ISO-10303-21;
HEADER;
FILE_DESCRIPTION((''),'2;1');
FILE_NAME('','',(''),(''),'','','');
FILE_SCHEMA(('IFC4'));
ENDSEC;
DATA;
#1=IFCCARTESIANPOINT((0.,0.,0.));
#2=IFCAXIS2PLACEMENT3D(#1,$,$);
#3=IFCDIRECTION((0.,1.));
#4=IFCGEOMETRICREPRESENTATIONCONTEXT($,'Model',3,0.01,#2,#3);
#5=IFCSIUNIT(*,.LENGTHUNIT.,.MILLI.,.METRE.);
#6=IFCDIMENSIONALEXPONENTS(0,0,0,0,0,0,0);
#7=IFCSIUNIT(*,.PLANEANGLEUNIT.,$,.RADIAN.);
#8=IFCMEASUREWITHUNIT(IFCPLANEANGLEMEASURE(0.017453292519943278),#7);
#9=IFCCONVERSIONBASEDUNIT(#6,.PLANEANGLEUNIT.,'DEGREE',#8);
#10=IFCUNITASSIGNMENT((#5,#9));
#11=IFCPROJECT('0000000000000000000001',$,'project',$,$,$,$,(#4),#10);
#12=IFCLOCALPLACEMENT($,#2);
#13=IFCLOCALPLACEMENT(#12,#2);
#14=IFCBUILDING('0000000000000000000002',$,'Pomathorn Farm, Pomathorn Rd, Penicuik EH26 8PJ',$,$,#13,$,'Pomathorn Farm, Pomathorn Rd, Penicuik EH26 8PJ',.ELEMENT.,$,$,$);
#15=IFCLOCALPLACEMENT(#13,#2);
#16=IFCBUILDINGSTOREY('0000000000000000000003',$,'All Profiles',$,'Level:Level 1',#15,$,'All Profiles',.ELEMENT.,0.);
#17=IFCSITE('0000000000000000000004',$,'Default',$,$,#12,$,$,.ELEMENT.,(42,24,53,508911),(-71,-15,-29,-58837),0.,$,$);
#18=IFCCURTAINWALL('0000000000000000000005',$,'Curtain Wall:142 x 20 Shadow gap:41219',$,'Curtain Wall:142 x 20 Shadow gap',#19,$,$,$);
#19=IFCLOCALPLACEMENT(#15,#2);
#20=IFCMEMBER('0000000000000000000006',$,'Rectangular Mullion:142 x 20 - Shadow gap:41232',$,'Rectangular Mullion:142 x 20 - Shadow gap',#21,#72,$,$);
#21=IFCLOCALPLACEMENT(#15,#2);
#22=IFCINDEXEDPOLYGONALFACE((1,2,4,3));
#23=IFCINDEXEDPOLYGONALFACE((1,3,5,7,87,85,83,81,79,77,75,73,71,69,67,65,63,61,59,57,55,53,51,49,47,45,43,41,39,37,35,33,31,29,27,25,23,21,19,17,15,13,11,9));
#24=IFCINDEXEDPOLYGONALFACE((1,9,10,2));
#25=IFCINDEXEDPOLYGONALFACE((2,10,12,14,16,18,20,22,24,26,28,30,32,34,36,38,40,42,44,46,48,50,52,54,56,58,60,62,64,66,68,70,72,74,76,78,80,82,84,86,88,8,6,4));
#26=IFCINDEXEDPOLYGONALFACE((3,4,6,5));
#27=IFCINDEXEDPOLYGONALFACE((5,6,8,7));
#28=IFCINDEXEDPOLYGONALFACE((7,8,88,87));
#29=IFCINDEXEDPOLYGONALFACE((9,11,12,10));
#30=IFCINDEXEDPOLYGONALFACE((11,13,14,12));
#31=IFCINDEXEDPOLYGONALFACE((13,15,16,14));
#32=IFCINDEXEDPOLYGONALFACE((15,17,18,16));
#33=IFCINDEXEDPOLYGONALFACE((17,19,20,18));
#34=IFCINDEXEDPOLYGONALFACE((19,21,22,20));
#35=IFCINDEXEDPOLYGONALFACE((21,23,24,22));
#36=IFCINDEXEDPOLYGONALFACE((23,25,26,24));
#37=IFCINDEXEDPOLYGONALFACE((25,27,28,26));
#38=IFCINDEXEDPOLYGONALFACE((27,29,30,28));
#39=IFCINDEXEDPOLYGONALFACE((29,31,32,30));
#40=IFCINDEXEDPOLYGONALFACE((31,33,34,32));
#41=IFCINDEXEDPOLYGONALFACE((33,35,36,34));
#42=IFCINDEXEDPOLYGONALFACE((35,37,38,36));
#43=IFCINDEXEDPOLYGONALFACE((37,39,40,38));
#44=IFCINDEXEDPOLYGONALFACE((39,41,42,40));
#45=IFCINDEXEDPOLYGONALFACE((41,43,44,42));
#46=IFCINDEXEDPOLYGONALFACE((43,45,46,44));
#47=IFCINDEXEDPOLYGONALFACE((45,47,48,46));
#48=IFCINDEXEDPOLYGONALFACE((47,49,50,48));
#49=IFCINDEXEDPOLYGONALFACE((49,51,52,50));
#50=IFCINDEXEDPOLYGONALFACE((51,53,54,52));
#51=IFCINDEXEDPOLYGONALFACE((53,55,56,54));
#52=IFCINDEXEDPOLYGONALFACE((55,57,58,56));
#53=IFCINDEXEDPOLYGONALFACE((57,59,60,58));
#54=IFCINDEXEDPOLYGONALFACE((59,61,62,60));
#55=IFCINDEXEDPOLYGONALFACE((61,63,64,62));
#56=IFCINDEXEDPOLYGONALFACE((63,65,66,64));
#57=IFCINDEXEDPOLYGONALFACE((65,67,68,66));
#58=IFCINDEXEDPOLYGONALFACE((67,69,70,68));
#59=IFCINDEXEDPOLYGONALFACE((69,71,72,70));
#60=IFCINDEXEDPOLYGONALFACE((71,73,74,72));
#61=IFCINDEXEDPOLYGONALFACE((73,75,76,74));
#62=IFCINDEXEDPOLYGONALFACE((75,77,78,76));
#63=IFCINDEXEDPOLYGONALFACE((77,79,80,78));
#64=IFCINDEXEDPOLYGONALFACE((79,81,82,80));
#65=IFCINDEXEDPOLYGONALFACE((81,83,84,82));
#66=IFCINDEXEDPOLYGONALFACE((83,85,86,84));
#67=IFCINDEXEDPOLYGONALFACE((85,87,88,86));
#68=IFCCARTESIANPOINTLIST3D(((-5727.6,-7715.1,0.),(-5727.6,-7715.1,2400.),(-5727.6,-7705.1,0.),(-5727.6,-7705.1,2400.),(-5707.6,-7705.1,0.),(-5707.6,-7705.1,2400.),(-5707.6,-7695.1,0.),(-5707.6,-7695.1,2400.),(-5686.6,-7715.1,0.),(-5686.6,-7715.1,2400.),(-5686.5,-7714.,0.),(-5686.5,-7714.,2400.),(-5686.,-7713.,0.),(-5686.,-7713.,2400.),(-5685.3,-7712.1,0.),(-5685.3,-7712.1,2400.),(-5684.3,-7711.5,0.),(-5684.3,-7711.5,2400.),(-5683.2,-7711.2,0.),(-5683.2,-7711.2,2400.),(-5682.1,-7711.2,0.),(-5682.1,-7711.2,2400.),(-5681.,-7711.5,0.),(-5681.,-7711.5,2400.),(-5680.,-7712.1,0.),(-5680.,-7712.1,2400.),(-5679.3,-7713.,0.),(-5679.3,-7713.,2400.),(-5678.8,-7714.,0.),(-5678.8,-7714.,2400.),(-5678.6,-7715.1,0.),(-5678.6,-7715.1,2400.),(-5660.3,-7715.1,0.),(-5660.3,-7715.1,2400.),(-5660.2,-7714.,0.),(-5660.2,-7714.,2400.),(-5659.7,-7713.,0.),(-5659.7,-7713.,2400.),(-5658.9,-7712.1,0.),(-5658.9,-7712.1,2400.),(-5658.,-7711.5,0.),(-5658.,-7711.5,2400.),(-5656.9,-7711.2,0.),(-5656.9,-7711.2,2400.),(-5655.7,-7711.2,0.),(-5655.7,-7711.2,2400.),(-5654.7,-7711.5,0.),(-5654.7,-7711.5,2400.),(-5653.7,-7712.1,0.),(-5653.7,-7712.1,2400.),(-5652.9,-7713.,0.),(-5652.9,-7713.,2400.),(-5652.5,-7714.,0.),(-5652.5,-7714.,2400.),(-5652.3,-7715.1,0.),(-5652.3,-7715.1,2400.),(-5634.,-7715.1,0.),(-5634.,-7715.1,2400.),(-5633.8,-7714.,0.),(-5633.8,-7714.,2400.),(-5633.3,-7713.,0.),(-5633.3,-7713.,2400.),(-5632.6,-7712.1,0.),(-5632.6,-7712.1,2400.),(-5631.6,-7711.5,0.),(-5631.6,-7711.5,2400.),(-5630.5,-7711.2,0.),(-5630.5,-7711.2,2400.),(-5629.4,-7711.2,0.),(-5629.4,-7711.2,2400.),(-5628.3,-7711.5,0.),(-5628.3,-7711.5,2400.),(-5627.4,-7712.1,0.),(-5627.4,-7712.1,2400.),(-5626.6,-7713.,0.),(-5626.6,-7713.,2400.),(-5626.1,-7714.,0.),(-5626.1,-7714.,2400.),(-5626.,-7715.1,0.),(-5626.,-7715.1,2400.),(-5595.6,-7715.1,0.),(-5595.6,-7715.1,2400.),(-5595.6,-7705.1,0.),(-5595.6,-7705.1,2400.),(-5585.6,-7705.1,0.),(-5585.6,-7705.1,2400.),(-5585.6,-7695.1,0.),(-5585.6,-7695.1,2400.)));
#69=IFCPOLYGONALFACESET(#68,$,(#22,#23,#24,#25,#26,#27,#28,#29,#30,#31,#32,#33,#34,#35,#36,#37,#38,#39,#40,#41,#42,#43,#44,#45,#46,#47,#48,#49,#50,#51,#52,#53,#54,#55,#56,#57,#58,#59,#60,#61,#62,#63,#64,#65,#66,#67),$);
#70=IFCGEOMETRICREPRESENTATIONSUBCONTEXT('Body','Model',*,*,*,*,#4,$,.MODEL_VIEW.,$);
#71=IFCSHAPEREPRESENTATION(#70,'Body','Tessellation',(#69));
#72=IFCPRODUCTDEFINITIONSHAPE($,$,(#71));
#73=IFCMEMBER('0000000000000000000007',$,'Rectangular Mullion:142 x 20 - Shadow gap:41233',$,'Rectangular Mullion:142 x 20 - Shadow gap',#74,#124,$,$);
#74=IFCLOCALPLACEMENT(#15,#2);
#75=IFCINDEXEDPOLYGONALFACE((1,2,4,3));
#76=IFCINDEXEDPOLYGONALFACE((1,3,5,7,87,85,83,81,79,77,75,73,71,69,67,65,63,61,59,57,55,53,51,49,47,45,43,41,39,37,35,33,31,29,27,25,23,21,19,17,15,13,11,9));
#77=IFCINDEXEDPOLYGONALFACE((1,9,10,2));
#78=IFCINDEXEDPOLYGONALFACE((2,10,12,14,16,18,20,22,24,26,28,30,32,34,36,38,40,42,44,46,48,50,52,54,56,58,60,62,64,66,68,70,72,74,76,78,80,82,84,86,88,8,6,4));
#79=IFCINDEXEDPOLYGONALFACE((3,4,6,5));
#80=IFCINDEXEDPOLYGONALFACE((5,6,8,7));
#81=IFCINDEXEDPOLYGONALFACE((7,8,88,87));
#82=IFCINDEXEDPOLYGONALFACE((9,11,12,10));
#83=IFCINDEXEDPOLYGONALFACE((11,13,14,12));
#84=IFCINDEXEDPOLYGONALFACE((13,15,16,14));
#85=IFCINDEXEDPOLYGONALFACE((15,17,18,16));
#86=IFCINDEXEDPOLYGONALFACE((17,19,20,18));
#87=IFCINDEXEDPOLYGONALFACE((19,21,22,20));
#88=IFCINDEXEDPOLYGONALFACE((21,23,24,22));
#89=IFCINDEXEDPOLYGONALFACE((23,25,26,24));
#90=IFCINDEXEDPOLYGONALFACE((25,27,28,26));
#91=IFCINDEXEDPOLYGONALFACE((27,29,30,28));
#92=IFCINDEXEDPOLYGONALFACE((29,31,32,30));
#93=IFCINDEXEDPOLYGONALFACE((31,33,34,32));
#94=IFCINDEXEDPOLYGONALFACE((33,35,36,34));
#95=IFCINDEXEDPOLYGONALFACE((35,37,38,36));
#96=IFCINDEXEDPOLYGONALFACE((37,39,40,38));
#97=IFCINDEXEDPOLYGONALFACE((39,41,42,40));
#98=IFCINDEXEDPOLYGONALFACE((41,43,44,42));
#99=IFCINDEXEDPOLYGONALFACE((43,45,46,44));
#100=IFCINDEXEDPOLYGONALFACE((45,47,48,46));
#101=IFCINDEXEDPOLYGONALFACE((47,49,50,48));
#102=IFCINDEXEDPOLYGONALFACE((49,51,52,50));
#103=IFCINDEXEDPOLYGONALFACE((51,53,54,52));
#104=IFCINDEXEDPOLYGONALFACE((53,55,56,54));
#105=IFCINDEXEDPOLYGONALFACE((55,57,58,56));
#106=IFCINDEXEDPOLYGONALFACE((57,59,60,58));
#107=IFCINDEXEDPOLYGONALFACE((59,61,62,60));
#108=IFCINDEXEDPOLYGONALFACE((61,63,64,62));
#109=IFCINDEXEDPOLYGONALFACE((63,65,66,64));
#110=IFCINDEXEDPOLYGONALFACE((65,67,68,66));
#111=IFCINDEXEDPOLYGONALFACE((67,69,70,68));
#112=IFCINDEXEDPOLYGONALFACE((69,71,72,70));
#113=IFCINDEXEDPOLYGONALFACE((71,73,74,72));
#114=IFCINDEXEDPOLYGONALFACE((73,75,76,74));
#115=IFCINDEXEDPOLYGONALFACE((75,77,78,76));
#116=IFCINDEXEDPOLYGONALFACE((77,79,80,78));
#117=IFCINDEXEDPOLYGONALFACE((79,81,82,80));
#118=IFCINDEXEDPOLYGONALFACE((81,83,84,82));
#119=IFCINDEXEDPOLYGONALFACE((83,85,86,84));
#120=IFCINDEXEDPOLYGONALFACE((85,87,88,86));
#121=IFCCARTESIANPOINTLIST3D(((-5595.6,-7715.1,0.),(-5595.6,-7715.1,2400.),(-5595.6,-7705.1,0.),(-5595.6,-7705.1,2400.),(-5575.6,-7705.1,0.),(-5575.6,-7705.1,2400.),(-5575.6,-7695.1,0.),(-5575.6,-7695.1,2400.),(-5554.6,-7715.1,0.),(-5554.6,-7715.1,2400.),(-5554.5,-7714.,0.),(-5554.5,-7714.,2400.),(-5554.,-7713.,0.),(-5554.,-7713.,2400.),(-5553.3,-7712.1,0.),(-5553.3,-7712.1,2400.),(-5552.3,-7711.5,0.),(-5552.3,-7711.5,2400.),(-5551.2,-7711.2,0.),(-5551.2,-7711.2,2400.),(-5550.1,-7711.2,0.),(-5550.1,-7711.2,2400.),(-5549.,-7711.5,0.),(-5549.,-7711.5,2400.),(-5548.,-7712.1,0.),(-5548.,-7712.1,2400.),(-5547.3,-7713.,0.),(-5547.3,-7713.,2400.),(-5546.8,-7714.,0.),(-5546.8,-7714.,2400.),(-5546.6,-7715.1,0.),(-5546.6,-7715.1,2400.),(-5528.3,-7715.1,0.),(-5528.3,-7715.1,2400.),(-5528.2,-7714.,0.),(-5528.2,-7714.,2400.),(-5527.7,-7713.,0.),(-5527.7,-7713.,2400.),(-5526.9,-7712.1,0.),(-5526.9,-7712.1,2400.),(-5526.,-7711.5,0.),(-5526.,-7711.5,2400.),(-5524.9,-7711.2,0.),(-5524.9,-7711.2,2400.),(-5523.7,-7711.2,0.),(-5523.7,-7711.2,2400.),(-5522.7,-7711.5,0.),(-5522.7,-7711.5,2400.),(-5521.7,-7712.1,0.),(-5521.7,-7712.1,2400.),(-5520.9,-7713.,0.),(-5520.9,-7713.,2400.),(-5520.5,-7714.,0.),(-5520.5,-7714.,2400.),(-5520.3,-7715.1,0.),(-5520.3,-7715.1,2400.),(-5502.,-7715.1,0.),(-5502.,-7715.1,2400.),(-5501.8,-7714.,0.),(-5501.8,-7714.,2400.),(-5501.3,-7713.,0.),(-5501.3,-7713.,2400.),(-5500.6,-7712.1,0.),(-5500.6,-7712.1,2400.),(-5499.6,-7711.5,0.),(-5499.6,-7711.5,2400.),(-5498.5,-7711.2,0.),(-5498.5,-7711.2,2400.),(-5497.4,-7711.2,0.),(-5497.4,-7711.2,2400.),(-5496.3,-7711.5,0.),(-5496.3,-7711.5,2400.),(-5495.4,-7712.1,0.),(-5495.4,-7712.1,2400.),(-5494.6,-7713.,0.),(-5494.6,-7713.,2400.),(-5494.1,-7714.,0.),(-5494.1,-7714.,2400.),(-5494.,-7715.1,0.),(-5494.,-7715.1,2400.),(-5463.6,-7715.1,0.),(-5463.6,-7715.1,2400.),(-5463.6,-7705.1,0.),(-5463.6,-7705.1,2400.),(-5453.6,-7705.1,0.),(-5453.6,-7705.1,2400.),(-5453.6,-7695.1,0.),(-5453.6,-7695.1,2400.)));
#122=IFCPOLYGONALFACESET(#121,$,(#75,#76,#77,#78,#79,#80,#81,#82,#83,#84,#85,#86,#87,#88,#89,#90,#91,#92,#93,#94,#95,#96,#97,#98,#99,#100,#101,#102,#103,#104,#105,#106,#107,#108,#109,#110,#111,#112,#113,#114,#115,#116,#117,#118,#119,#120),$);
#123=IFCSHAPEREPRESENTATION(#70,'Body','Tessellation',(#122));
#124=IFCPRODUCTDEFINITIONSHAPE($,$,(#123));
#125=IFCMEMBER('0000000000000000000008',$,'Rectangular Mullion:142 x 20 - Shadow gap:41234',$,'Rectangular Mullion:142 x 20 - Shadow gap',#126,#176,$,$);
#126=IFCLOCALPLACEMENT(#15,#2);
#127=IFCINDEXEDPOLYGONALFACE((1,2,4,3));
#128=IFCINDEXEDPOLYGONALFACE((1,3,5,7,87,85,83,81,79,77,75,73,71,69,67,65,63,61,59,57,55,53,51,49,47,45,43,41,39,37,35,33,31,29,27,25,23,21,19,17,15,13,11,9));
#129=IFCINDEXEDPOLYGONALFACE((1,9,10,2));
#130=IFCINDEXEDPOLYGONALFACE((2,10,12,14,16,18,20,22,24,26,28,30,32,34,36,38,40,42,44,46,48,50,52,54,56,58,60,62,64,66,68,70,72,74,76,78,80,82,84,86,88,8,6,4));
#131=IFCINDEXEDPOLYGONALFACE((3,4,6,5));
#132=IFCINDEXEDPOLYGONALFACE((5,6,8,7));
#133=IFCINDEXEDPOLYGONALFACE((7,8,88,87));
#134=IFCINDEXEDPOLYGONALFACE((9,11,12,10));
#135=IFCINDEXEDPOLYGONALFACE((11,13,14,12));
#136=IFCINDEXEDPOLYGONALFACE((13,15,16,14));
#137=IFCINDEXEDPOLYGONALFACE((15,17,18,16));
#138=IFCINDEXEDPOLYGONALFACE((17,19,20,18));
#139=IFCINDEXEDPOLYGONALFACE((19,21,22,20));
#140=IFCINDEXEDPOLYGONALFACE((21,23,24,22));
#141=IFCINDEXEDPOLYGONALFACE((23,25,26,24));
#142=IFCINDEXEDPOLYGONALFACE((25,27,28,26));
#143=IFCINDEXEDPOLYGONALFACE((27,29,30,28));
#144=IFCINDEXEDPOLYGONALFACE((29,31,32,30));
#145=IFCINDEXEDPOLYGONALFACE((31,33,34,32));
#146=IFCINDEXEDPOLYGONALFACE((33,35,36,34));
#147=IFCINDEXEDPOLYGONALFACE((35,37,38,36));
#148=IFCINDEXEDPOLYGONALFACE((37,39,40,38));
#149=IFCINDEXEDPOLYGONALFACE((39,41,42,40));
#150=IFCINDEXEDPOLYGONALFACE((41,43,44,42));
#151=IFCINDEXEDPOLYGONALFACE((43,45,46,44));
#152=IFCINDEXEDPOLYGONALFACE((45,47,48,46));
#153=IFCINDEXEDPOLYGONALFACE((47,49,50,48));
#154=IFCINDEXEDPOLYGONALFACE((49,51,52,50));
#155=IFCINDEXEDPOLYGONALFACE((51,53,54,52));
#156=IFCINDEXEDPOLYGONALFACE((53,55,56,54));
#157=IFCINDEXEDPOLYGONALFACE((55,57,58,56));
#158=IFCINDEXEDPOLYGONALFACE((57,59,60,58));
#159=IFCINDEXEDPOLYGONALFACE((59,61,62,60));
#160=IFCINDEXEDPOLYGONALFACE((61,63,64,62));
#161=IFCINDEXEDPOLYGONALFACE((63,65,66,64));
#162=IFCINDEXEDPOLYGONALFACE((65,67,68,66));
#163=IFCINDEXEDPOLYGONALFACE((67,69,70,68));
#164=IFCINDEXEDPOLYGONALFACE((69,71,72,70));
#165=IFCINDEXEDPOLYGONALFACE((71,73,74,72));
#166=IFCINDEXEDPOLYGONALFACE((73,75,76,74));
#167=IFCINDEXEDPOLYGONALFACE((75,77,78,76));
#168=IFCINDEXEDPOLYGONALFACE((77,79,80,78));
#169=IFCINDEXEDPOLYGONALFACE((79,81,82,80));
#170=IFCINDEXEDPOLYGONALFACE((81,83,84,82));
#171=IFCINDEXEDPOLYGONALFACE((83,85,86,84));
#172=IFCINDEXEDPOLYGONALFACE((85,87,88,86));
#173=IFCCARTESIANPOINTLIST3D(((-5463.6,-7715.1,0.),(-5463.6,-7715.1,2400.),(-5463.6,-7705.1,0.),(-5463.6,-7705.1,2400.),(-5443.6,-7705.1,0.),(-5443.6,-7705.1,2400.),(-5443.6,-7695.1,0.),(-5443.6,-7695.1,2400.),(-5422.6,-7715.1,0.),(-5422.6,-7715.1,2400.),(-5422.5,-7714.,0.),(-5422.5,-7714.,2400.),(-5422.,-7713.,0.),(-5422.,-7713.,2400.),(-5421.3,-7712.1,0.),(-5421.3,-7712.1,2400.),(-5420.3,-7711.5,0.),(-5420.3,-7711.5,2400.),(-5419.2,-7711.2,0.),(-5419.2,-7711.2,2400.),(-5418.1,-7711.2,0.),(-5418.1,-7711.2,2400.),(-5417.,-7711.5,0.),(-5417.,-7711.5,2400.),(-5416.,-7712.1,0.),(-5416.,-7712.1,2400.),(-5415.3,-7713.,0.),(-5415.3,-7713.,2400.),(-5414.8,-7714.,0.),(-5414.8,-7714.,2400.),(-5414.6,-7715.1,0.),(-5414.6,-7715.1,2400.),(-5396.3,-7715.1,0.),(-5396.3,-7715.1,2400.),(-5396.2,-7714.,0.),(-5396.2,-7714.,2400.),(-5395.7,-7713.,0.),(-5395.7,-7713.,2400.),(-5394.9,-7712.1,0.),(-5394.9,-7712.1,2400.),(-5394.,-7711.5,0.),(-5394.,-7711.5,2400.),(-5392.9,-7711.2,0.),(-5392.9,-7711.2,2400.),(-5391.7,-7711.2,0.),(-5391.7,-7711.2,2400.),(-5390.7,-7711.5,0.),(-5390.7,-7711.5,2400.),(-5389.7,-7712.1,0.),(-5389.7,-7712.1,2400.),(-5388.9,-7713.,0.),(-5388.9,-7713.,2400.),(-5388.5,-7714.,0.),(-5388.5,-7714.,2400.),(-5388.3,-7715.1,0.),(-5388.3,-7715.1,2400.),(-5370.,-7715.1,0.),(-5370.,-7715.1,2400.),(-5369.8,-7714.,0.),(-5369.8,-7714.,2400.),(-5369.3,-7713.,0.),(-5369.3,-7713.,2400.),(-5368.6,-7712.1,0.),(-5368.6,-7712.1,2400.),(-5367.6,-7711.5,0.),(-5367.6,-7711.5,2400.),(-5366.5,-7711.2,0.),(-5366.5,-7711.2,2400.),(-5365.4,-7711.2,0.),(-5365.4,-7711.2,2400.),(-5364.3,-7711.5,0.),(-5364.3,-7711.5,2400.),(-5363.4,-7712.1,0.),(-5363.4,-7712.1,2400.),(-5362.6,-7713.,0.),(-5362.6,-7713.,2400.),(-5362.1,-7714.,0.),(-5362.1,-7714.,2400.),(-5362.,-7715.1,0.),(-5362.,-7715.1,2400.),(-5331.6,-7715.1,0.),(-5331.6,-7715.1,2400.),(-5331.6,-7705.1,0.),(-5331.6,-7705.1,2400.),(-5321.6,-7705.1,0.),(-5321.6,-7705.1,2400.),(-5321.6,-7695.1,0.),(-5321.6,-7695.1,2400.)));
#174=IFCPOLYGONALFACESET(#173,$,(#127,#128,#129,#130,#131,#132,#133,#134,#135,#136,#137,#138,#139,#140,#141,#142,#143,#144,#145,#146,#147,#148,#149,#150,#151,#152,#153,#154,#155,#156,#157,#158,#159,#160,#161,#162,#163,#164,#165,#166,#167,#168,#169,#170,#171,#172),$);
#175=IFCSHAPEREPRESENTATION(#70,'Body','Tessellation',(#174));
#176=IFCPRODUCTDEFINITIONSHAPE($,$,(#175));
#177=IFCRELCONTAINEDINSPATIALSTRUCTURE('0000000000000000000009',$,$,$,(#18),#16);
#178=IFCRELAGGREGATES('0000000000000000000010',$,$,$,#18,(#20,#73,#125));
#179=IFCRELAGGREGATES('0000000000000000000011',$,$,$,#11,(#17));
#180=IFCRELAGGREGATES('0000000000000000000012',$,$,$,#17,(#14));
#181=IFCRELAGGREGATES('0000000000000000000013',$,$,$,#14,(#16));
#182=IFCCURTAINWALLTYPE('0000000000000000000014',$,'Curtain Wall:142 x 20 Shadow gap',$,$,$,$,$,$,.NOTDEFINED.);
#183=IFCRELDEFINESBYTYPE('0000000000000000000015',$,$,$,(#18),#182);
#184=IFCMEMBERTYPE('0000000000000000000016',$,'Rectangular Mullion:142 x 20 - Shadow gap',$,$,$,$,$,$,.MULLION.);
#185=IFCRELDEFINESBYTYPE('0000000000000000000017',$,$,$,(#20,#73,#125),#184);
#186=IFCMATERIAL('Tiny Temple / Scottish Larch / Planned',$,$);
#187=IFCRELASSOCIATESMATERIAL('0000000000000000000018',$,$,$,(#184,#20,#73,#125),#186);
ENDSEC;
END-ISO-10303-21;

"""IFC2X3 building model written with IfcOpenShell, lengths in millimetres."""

from ifc_helpers import new_model, entity, si_unit, converted_unit, direction, frame, frame_2d, origin, place, context, subcontext, project, spatial, polyline, circle_curve, parameter, trimmed, segment, composite_curve, outline, extrude, source, transform, mapped, material, type_object, type_shapes, element, aggregate, save


model = new_model("IFC2X3")

# Units and contexts
model_context = context("Model", 3, precision=0.01, world=origin(), true_north=direction((0.0, 1.0)))
body_context = subcontext(model_context, "Body", "Model", "MODEL_VIEW")
ifc_project = project(units=[si_unit("LENGTHUNIT", "METRE", prefix="MILLI"), converted_unit("PLANEANGLEUNIT", "DEGREE", entity("IfcPlaneAngleMeasure", 0.017453292519943278), si_unit("PLANEANGLEUNIT", "RADIAN"), dimensions=[0, 0, 0, 0, 0, 0, 0])], contexts=[model_context])

# Site, building, storey
site_placement = place(None, origin())
site = spatial("IfcSite", under=ifc_project, at=site_placement, Name="Default", CompositionType="ELEMENT", RefLatitude=(42, 24, 53, 508911), RefLongitude=(-71, -15, -29, -58837), RefElevation=0.0)
building_placement = place(site_placement, origin())
building = spatial("IfcBuilding", under=site, at=building_placement, Name="Pomathorn Farm, Pomathorn Rd, Penicuik EH26 8PJ", LongName="Pomathorn Farm, Pomathorn Rd, Penicuik EH26 8PJ", CompositionType="ELEMENT")
storey_placement = place(building_placement, origin())
storey = spatial("IfcBuildingStorey", under=building, at=storey_placement, Name="All Profiles", ObjectType="Level:Level 1", LongName="All Profiles", CompositionType="ELEMENT", Elevation=0.0)

# Curtain wall, members
curtain_wall_type_1 = type_object("IfcCurtainWallType", Name="Curtain Wall:142 x 20 Shadow gap", PredefinedType="NOTDEFINED")
curtain_wall_1_placement = place(storey_placement, origin())
curtain_wall_1 = element("IfcCurtainWall", 1, at=curtain_wall_1_placement, inside=storey, type_object=curtain_wall_type_1, Name="Curtain Wall:142 x 20 Shadow gap:41219", ObjectType="Curtain Wall:142 x 20 Shadow gap")
ifc_material = material(Name="Tiny Temple / Scottish Larch / Planned")
member_type_1 = type_object("IfcMemberType", Name="Rectangular Mullion:142 x 20 - Shadow gap", PredefinedType="MULLION", material=ifc_material)
shared_shape_1 = source(origin(), body_context, "Body", "SweptSolid", [
    extrude(outline(composite_curve([segment(polyline([(29.1, -5.7), (59.4, -5.7)]), True, "CONTINUOUS"), segment(polyline([(59.4, -5.7), (59.4, 4.3)]), True, "CONTINUOUS"), segment(polyline([(59.4, 4.3), (69.4, 4.3)]), True, "CONTINUOUS"), segment(polyline([(69.4, 4.3), (69.4, 14.3)]), True, "CONTINUOUS"), segment(polyline([(69.4, 14.3), (-52.6, 14.3)]), True, "CONTINUOUS"), segment(polyline([(-52.6, 14.3), (-52.6, 4.3)]), True, "CONTINUOUS"), segment(polyline([(-52.6, 4.3), (-72.6, 4.3)]), True, "CONTINUOUS"), segment(polyline([(-72.6, 4.3), (-72.6, -5.7)]), True, "CONTINUOUS"), segment(polyline([(-72.6, -5.7), (-31.6, -5.7)]), True, "CONTINUOUS"), segment(trimmed(circle_curve(frame_2d((-27.6, -5.7), x_axis=(1.0, 0.0)), 4.0), [parameter(360.0)], [parameter(180.0)], True, "PARAMETER"), False, "CONTINUOUS"), segment(polyline([(-23.6, -5.7), (-5.2, -5.7)]), True, "CONTINUOUS"), segment(trimmed(circle_curve(frame_2d((-1.2, -5.7), x_axis=(1.0, 0.0)), 4.0), [parameter(360.0)], [parameter(180.0)], True, "PARAMETER"), False, "CONTINUOUS"), segment(polyline([(2.8, -5.7), (21.1, -5.7)]), True, "CONTINUOUS"), segment(trimmed(circle_curve(frame_2d((25.1, -5.7), x_axis=(1.0, 0.0)), 4.0), [parameter(360.0)], [parameter(180.0)], True, "PARAMETER"), False, "CONTINUOUS")], self_intersect=False)), frame((-69.4, -5.7, -2400.0), z_axis=(0.0, 0.0, -1.0), x_axis=(1.0, 0.0, 0.0)), (0.0, 0.0, -1.0), 2400.0),
])
type_shapes(member_type_1, [shared_shape_1])
member_1_placement = place(curtain_wall_1_placement, frame((-5585.6, -7715.1, 0.0), z_axis=(0.0, 0.0, -1.0), x_axis=(1.0, 0.0, 0.0)))
member_1 = element("IfcMember", 2, at=member_1_placement, type_object=member_type_1, material=ifc_material, Name="Rectangular Mullion:142 x 20 - Shadow gap:41232", ObjectType="Rectangular Mullion:142 x 20 - Shadow gap", context=body_context, shape_type="MappedRepresentation", body=[
    mapped(shared_shape_1, transform((0.0, 0.0, 0.0), scale=1.0)),
])
member_2_placement = place(curtain_wall_1_placement, frame((-5453.6, -7715.1, 0.0), z_axis=(0.0, 0.0, -1.0), x_axis=(1.0, 0.0, 0.0)))
member_2 = element("IfcMember", 3, at=member_2_placement, type_object=member_type_1, material=ifc_material, Name="Rectangular Mullion:142 x 20 - Shadow gap:41233", ObjectType="Rectangular Mullion:142 x 20 - Shadow gap", context=body_context, shape_type="MappedRepresentation", body=[
    mapped(shared_shape_1, transform((0.0, 0.0, 0.0), scale=1.0)),
])
member_3_placement = place(curtain_wall_1_placement, frame((-5321.6, -7715.1, 0.0), z_axis=(0.0, 0.0, -1.0), x_axis=(1.0, 0.0, 0.0)))
member_3 = element("IfcMember", 4, at=member_3_placement, type_object=member_type_1, material=ifc_material, Name="Rectangular Mullion:142 x 20 - Shadow gap:41234", ObjectType="Rectangular Mullion:142 x 20 - Shadow gap", context=body_context, shape_type="MappedRepresentation", body=[
    mapped(shared_shape_1, transform((0.0, 0.0, 0.0), scale=1.0)),
])
aggregate(curtain_wall_1, [member_1, member_2, member_3])

save(model, "model.ifc")
